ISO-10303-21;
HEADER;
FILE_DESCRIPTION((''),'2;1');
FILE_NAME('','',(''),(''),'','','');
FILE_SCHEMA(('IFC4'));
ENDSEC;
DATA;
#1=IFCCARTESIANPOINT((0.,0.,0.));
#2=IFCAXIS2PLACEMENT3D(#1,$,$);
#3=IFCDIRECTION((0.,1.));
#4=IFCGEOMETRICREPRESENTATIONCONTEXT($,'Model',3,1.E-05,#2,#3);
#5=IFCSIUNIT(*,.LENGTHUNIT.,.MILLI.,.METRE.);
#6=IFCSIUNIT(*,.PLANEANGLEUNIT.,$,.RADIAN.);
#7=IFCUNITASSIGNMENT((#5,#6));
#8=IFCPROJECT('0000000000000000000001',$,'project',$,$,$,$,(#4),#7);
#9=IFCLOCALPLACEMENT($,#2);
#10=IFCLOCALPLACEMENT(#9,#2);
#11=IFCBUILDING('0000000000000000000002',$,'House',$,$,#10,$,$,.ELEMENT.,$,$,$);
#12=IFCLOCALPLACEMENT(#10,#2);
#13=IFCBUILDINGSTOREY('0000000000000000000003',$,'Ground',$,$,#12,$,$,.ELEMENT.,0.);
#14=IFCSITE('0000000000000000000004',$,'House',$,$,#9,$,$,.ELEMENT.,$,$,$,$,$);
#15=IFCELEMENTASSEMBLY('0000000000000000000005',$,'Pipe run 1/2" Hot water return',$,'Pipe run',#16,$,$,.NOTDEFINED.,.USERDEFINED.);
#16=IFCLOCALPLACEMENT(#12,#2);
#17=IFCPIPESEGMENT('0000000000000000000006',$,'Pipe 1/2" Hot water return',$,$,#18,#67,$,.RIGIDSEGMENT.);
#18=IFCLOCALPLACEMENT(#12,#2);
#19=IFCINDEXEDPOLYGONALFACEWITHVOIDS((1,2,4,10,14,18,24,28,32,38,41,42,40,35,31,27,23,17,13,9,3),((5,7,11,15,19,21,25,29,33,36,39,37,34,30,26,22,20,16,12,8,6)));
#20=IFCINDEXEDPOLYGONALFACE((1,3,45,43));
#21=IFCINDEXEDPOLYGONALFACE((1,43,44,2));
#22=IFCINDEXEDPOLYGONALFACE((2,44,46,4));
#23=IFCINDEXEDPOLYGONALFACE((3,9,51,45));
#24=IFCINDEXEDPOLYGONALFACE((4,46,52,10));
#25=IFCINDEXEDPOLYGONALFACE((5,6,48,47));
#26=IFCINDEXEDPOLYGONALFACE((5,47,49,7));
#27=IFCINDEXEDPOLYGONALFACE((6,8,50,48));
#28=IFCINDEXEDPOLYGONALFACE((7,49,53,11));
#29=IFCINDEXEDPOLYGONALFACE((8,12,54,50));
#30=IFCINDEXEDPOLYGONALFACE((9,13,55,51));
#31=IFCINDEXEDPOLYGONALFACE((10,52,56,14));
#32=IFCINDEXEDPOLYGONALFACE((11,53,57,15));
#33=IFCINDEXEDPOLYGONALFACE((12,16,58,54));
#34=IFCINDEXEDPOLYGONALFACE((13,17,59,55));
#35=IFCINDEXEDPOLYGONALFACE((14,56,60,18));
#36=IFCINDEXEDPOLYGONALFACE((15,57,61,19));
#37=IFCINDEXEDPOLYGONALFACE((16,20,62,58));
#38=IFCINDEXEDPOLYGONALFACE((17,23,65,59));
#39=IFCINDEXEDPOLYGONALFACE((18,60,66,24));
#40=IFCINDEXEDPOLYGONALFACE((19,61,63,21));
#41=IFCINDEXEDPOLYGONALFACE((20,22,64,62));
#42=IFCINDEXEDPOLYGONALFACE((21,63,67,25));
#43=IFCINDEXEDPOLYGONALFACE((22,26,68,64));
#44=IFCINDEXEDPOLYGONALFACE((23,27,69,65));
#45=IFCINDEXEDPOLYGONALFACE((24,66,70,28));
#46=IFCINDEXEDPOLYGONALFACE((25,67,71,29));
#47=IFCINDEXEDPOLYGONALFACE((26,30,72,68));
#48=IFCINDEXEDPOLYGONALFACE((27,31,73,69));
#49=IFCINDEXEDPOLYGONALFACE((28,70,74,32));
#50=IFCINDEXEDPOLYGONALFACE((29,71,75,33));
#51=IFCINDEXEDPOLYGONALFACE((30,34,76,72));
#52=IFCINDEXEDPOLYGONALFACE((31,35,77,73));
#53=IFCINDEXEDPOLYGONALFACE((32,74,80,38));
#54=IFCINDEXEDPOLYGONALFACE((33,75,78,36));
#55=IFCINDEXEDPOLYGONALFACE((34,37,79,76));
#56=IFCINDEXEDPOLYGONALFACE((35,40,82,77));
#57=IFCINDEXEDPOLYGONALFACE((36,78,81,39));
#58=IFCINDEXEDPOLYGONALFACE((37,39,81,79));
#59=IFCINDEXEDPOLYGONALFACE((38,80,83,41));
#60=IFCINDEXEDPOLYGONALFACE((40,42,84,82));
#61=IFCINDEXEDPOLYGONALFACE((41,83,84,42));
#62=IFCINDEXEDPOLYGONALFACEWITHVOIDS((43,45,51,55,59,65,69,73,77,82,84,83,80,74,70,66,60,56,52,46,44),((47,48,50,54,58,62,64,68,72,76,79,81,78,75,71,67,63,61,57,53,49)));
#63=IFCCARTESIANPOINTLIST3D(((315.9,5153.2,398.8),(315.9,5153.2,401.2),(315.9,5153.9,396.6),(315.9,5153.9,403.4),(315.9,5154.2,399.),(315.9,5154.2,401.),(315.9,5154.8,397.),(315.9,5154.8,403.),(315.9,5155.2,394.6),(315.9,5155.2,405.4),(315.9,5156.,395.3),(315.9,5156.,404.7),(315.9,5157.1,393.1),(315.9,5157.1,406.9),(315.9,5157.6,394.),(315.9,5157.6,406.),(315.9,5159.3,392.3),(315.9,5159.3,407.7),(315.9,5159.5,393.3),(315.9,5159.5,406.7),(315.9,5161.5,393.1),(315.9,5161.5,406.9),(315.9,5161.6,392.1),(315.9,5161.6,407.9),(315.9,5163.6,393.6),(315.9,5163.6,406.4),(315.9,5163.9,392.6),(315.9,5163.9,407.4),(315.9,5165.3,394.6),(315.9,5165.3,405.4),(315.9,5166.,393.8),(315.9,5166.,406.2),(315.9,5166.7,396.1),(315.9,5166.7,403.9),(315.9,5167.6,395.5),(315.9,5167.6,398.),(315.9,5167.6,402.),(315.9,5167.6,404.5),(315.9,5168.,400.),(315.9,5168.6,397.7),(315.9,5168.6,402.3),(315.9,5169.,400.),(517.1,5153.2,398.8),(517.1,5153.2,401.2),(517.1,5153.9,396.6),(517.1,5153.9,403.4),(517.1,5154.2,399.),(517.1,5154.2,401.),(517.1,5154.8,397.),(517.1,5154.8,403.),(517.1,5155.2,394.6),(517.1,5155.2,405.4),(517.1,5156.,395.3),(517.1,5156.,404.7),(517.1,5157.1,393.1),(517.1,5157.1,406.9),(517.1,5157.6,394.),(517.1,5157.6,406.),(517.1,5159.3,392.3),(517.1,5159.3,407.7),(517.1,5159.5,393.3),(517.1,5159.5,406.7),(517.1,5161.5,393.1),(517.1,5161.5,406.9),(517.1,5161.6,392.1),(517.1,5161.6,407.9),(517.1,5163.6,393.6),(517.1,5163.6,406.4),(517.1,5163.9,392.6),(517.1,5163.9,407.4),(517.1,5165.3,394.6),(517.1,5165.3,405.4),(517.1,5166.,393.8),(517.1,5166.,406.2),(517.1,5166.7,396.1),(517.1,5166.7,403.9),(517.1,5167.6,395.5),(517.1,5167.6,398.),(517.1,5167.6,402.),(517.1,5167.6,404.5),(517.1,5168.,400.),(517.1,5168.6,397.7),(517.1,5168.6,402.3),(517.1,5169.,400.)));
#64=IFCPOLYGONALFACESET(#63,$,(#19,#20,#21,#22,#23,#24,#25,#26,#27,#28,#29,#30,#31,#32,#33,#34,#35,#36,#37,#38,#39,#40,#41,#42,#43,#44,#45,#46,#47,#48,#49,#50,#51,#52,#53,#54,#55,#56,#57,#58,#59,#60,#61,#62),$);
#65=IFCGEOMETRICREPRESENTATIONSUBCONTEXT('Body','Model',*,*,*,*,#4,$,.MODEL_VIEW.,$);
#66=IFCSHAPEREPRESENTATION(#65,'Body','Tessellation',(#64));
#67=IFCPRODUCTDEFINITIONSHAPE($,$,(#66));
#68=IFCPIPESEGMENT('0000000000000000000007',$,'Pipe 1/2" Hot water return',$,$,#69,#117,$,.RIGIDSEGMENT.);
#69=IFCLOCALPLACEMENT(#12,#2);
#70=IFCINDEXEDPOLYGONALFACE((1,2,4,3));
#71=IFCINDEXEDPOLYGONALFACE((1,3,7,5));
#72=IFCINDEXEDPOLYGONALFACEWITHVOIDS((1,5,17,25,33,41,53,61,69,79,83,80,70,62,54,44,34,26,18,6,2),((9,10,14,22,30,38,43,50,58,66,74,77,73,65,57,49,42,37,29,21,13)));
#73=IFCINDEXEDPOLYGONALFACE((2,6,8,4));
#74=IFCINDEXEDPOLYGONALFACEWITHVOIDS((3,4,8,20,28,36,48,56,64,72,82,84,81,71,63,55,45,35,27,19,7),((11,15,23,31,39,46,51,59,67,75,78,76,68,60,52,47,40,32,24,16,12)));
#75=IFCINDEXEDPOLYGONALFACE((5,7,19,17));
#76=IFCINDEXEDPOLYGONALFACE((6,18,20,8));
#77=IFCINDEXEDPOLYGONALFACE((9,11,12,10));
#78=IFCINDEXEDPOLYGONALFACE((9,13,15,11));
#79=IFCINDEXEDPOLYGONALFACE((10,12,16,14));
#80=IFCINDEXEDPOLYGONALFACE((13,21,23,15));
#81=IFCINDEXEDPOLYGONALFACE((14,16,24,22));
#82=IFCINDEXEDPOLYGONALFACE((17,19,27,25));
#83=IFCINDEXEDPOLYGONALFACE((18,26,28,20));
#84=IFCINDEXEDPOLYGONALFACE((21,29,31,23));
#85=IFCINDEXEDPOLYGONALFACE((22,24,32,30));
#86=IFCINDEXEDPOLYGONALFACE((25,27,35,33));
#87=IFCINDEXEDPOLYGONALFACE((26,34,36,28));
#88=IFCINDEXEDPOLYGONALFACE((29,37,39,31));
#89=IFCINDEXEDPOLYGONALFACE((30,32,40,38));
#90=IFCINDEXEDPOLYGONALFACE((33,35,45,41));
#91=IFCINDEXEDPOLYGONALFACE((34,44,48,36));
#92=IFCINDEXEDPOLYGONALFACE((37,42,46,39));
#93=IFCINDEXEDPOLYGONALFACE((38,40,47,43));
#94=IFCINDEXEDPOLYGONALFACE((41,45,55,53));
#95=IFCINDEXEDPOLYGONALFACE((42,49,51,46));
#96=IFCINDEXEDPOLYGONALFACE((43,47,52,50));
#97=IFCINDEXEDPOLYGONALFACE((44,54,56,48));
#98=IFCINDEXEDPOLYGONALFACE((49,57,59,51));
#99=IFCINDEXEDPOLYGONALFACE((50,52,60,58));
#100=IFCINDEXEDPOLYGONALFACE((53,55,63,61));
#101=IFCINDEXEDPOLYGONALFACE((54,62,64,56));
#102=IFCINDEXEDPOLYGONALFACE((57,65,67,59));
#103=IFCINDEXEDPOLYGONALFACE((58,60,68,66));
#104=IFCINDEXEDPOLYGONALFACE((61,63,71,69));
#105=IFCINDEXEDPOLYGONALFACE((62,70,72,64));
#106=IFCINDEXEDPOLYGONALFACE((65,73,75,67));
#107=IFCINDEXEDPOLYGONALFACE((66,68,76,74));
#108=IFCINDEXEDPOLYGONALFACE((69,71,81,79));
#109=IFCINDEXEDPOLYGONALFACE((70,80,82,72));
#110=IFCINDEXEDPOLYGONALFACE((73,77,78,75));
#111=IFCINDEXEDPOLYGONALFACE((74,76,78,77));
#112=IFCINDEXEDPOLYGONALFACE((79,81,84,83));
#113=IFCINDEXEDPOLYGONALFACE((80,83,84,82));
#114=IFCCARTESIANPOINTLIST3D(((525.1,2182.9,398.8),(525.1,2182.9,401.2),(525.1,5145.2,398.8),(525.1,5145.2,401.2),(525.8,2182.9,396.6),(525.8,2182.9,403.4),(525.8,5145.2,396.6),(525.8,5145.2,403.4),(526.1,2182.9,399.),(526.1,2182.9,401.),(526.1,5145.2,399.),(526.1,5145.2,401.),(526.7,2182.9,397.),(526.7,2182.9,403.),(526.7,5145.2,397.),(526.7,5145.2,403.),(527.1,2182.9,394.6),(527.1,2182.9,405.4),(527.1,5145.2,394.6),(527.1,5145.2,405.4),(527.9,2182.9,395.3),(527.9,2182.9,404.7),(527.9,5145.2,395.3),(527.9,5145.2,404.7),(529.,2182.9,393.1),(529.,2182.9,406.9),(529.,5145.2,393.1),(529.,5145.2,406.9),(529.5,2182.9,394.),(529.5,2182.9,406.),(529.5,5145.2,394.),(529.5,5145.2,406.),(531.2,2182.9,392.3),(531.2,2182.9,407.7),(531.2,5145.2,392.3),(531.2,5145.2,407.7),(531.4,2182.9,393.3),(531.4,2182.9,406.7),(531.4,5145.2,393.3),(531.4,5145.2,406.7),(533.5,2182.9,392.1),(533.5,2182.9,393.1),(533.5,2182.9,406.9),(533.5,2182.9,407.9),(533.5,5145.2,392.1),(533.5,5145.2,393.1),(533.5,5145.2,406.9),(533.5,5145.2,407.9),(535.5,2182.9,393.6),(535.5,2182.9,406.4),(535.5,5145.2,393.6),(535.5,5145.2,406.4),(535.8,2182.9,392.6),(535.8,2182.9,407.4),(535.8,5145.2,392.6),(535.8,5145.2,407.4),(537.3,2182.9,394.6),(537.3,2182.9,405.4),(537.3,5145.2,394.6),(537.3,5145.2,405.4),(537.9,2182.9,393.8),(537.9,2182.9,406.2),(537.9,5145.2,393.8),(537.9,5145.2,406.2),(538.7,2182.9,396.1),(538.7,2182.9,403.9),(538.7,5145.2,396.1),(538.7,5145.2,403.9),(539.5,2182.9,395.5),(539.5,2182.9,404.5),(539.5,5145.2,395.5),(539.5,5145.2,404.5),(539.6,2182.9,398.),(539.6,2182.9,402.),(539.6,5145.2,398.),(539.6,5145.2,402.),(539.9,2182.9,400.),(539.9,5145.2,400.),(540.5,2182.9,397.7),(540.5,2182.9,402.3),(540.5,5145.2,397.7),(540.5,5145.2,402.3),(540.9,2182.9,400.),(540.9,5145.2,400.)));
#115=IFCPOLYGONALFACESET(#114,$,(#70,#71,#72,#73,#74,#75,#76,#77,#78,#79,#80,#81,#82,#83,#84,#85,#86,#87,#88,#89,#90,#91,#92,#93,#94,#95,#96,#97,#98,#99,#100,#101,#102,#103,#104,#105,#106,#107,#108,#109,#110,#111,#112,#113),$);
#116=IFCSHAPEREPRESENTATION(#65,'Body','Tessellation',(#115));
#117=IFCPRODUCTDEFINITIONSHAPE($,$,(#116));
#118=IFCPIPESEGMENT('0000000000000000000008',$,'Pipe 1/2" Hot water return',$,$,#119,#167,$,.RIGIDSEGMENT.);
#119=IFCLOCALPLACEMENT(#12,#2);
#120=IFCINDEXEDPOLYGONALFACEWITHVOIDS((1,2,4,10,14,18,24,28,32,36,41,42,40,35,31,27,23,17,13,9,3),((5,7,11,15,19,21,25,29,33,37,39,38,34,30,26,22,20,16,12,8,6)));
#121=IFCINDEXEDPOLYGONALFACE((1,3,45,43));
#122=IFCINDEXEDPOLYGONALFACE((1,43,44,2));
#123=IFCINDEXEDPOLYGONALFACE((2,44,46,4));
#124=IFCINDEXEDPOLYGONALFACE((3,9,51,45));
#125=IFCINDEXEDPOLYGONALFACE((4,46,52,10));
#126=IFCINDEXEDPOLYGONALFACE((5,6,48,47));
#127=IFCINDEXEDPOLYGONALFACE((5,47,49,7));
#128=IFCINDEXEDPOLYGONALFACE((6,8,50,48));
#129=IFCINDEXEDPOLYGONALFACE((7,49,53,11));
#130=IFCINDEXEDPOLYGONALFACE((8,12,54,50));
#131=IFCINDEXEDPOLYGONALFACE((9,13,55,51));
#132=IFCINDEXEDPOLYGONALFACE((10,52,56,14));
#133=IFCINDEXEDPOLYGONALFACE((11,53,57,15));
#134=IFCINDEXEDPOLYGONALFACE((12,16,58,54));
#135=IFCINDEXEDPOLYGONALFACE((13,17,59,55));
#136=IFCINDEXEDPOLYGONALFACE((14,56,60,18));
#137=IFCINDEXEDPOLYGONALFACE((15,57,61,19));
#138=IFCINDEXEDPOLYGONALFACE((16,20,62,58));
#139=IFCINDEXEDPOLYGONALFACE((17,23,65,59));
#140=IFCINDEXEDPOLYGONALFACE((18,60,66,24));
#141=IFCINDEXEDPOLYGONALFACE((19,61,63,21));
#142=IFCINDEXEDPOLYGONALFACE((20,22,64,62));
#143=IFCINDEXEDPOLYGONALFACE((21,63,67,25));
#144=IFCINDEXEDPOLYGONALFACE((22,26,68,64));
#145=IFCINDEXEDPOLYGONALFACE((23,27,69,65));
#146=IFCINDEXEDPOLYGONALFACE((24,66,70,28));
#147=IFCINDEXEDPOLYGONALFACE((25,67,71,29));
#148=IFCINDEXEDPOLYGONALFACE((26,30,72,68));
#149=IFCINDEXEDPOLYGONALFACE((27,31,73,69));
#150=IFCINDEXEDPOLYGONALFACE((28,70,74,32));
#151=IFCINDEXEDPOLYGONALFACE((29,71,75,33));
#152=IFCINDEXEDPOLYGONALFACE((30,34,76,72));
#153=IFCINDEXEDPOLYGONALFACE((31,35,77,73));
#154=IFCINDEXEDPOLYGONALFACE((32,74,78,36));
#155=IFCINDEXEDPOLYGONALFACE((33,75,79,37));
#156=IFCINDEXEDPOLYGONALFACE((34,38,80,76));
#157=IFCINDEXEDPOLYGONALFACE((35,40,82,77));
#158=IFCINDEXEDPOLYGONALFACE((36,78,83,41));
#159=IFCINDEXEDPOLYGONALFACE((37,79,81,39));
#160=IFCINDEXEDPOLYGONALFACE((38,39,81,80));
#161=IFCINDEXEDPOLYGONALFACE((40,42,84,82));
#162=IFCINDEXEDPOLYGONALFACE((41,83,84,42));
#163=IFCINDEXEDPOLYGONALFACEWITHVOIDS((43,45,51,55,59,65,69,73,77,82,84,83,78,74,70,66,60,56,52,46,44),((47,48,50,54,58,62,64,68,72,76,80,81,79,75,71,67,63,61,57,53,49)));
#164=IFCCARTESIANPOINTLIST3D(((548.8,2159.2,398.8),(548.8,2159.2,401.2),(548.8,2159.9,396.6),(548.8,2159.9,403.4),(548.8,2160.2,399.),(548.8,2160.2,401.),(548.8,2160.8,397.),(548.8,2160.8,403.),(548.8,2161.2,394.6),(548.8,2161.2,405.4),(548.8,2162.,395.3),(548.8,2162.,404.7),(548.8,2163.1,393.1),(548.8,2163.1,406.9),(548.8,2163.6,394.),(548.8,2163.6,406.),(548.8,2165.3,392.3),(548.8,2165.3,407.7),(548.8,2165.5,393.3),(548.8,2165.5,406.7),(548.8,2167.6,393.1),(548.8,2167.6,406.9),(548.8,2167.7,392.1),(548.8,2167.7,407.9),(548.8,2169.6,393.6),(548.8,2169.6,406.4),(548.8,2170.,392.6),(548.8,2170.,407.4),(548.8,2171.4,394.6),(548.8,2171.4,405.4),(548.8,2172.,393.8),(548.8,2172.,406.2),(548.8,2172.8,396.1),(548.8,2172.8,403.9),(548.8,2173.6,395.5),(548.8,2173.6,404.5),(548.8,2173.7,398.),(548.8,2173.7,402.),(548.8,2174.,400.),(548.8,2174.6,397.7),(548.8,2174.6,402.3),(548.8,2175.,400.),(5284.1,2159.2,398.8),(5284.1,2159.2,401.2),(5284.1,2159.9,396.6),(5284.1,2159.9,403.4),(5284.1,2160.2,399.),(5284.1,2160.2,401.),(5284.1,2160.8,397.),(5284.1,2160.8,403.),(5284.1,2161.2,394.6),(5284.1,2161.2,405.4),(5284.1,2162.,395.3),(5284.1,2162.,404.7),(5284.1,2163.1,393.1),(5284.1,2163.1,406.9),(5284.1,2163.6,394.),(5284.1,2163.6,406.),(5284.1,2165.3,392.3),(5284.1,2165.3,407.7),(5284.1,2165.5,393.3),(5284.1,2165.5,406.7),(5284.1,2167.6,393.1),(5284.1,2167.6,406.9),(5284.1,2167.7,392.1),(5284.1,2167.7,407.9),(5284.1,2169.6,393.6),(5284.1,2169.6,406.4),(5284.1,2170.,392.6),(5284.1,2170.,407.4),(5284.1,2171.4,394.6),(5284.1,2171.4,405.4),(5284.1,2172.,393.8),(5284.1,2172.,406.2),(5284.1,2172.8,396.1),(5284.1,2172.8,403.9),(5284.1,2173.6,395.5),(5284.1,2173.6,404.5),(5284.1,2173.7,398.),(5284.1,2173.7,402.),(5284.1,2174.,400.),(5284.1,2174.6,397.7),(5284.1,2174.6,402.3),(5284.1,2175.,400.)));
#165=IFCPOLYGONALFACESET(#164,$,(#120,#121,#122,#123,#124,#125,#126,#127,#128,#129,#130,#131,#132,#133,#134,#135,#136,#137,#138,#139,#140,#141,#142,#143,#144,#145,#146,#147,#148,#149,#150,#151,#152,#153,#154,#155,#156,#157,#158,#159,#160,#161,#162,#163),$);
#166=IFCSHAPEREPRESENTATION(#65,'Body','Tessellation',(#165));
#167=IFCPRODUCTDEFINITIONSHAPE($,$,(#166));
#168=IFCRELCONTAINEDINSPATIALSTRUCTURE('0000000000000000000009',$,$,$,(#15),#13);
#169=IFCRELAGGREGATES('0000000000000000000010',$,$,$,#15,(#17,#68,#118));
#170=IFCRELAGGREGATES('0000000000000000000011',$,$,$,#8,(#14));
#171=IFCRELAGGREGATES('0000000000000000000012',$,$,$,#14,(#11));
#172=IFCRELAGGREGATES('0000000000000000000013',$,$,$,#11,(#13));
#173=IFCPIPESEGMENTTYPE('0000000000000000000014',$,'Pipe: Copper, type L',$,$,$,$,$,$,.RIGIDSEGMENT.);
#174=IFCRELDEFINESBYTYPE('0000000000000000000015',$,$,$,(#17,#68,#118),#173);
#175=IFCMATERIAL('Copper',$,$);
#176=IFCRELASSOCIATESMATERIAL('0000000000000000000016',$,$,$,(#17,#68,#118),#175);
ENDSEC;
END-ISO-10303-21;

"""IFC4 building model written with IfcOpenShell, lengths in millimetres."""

from ifc_helpers import new_model, si_unit, direction, frame, origin, origin_with_axes, origin_2d, place, context, subcontext, project, spatial, hollow_circle, extrude, material, type_object, element, aggregate, save


model = new_model("IFC4")

# Units and contexts
model_context = context("Model", 3, precision=1e-05, world=origin(), true_north=direction((0.0, 1.0)))
body_context = subcontext(model_context, "Body", "Model", "MODEL_VIEW")
ifc_project = project(units=[si_unit("LENGTHUNIT", "METRE", prefix="MILLI"), si_unit("PLANEANGLEUNIT", "RADIAN")], contexts=[model_context])

# Site, building, storey
site_placement = place(None, origin())
site = spatial("IfcSite", under=ifc_project, at=site_placement, Name="House", CompositionType="ELEMENT")
building_placement = place(site_placement, origin())
building = spatial("IfcBuilding", under=site, at=building_placement, Name="House", CompositionType="ELEMENT")
storey_placement = place(building_placement, origin())
storey = spatial("IfcBuildingStorey", under=building, at=storey_placement, Name="Ground", CompositionType="ELEMENT", Elevation=0.0)

# Element assembly, pipe segments
ifc_material = material(Name="Copper")
pipe_segment_type = type_object("IfcPipeSegmentType", Name="Pipe: Copper, type L", PredefinedType="RIGIDSEGMENT")
assembly_1_placement = place(storey_placement, origin_with_axes())
assembly_1 = element("IfcElementAssembly", 1, at=assembly_1_placement, inside=storey, Name="Pipe run 1/2\" Hot water return", ObjectType="Pipe run", AssemblyPlace="NOTDEFINED", PredefinedType="USERDEFINED")
pipe_segment_1_placement = place(storey_placement, origin_with_axes())
pipe_segment_1 = element("IfcPipeSegment", 2, at=pipe_segment_1_placement, type_object=pipe_segment_type, material=ifc_material, Name="Pipe 1/2\" Hot water return", PredefinedType="RIGIDSEGMENT", context=body_context, shape_type="SweptSolid", body=[
    extrude(hollow_circle(Radius=7.9, WallThickness=1.0, at=origin_2d()), frame((315.9, 5161.0, 400.0), z_axis=(1.0, 0.0, 0.0), x_axis=(0.0, 1.0, 0.0)), (0.0, 0.0, 1.0), 201.2),
])
pipe_segment_2_placement = place(storey_placement, origin_with_axes())
pipe_segment_2 = element("IfcPipeSegment", 3, at=pipe_segment_2_placement, type_object=pipe_segment_type, material=ifc_material, Name="Pipe 1/2\" Hot water return", PredefinedType="RIGIDSEGMENT", context=body_context, shape_type="SweptSolid", body=[
    extrude(hollow_circle(Radius=7.9, WallThickness=1.0, at=origin_2d()), frame((532.9, 5145.2, 400.0), z_axis=(0.0, -1.0, 0.0), x_axis=(1.0, 0.0, 0.0)), (0.0, 0.0, 1.0), 2962.2),
])
pipe_segment_3_placement = place(storey_placement, origin_with_axes())
pipe_segment_3 = element("IfcPipeSegment", 4, at=pipe_segment_3_placement, type_object=pipe_segment_type, material=ifc_material, Name="Pipe 1/2\" Hot water return", PredefinedType="RIGIDSEGMENT", context=body_context, shape_type="SweptSolid", body=[
    extrude(hollow_circle(Radius=7.9, WallThickness=1.0, at=origin_2d()), frame((548.8, 2167.1, 400.0), z_axis=(1.0, 0.0, 0.0), x_axis=(0.0, 1.0, 0.0)), (0.0, 0.0, 1.0), 4735.3),
])

aggregate(assembly_1, [pipe_segment_1, pipe_segment_2, pipe_segment_3])

save(model, "model.ifc")
